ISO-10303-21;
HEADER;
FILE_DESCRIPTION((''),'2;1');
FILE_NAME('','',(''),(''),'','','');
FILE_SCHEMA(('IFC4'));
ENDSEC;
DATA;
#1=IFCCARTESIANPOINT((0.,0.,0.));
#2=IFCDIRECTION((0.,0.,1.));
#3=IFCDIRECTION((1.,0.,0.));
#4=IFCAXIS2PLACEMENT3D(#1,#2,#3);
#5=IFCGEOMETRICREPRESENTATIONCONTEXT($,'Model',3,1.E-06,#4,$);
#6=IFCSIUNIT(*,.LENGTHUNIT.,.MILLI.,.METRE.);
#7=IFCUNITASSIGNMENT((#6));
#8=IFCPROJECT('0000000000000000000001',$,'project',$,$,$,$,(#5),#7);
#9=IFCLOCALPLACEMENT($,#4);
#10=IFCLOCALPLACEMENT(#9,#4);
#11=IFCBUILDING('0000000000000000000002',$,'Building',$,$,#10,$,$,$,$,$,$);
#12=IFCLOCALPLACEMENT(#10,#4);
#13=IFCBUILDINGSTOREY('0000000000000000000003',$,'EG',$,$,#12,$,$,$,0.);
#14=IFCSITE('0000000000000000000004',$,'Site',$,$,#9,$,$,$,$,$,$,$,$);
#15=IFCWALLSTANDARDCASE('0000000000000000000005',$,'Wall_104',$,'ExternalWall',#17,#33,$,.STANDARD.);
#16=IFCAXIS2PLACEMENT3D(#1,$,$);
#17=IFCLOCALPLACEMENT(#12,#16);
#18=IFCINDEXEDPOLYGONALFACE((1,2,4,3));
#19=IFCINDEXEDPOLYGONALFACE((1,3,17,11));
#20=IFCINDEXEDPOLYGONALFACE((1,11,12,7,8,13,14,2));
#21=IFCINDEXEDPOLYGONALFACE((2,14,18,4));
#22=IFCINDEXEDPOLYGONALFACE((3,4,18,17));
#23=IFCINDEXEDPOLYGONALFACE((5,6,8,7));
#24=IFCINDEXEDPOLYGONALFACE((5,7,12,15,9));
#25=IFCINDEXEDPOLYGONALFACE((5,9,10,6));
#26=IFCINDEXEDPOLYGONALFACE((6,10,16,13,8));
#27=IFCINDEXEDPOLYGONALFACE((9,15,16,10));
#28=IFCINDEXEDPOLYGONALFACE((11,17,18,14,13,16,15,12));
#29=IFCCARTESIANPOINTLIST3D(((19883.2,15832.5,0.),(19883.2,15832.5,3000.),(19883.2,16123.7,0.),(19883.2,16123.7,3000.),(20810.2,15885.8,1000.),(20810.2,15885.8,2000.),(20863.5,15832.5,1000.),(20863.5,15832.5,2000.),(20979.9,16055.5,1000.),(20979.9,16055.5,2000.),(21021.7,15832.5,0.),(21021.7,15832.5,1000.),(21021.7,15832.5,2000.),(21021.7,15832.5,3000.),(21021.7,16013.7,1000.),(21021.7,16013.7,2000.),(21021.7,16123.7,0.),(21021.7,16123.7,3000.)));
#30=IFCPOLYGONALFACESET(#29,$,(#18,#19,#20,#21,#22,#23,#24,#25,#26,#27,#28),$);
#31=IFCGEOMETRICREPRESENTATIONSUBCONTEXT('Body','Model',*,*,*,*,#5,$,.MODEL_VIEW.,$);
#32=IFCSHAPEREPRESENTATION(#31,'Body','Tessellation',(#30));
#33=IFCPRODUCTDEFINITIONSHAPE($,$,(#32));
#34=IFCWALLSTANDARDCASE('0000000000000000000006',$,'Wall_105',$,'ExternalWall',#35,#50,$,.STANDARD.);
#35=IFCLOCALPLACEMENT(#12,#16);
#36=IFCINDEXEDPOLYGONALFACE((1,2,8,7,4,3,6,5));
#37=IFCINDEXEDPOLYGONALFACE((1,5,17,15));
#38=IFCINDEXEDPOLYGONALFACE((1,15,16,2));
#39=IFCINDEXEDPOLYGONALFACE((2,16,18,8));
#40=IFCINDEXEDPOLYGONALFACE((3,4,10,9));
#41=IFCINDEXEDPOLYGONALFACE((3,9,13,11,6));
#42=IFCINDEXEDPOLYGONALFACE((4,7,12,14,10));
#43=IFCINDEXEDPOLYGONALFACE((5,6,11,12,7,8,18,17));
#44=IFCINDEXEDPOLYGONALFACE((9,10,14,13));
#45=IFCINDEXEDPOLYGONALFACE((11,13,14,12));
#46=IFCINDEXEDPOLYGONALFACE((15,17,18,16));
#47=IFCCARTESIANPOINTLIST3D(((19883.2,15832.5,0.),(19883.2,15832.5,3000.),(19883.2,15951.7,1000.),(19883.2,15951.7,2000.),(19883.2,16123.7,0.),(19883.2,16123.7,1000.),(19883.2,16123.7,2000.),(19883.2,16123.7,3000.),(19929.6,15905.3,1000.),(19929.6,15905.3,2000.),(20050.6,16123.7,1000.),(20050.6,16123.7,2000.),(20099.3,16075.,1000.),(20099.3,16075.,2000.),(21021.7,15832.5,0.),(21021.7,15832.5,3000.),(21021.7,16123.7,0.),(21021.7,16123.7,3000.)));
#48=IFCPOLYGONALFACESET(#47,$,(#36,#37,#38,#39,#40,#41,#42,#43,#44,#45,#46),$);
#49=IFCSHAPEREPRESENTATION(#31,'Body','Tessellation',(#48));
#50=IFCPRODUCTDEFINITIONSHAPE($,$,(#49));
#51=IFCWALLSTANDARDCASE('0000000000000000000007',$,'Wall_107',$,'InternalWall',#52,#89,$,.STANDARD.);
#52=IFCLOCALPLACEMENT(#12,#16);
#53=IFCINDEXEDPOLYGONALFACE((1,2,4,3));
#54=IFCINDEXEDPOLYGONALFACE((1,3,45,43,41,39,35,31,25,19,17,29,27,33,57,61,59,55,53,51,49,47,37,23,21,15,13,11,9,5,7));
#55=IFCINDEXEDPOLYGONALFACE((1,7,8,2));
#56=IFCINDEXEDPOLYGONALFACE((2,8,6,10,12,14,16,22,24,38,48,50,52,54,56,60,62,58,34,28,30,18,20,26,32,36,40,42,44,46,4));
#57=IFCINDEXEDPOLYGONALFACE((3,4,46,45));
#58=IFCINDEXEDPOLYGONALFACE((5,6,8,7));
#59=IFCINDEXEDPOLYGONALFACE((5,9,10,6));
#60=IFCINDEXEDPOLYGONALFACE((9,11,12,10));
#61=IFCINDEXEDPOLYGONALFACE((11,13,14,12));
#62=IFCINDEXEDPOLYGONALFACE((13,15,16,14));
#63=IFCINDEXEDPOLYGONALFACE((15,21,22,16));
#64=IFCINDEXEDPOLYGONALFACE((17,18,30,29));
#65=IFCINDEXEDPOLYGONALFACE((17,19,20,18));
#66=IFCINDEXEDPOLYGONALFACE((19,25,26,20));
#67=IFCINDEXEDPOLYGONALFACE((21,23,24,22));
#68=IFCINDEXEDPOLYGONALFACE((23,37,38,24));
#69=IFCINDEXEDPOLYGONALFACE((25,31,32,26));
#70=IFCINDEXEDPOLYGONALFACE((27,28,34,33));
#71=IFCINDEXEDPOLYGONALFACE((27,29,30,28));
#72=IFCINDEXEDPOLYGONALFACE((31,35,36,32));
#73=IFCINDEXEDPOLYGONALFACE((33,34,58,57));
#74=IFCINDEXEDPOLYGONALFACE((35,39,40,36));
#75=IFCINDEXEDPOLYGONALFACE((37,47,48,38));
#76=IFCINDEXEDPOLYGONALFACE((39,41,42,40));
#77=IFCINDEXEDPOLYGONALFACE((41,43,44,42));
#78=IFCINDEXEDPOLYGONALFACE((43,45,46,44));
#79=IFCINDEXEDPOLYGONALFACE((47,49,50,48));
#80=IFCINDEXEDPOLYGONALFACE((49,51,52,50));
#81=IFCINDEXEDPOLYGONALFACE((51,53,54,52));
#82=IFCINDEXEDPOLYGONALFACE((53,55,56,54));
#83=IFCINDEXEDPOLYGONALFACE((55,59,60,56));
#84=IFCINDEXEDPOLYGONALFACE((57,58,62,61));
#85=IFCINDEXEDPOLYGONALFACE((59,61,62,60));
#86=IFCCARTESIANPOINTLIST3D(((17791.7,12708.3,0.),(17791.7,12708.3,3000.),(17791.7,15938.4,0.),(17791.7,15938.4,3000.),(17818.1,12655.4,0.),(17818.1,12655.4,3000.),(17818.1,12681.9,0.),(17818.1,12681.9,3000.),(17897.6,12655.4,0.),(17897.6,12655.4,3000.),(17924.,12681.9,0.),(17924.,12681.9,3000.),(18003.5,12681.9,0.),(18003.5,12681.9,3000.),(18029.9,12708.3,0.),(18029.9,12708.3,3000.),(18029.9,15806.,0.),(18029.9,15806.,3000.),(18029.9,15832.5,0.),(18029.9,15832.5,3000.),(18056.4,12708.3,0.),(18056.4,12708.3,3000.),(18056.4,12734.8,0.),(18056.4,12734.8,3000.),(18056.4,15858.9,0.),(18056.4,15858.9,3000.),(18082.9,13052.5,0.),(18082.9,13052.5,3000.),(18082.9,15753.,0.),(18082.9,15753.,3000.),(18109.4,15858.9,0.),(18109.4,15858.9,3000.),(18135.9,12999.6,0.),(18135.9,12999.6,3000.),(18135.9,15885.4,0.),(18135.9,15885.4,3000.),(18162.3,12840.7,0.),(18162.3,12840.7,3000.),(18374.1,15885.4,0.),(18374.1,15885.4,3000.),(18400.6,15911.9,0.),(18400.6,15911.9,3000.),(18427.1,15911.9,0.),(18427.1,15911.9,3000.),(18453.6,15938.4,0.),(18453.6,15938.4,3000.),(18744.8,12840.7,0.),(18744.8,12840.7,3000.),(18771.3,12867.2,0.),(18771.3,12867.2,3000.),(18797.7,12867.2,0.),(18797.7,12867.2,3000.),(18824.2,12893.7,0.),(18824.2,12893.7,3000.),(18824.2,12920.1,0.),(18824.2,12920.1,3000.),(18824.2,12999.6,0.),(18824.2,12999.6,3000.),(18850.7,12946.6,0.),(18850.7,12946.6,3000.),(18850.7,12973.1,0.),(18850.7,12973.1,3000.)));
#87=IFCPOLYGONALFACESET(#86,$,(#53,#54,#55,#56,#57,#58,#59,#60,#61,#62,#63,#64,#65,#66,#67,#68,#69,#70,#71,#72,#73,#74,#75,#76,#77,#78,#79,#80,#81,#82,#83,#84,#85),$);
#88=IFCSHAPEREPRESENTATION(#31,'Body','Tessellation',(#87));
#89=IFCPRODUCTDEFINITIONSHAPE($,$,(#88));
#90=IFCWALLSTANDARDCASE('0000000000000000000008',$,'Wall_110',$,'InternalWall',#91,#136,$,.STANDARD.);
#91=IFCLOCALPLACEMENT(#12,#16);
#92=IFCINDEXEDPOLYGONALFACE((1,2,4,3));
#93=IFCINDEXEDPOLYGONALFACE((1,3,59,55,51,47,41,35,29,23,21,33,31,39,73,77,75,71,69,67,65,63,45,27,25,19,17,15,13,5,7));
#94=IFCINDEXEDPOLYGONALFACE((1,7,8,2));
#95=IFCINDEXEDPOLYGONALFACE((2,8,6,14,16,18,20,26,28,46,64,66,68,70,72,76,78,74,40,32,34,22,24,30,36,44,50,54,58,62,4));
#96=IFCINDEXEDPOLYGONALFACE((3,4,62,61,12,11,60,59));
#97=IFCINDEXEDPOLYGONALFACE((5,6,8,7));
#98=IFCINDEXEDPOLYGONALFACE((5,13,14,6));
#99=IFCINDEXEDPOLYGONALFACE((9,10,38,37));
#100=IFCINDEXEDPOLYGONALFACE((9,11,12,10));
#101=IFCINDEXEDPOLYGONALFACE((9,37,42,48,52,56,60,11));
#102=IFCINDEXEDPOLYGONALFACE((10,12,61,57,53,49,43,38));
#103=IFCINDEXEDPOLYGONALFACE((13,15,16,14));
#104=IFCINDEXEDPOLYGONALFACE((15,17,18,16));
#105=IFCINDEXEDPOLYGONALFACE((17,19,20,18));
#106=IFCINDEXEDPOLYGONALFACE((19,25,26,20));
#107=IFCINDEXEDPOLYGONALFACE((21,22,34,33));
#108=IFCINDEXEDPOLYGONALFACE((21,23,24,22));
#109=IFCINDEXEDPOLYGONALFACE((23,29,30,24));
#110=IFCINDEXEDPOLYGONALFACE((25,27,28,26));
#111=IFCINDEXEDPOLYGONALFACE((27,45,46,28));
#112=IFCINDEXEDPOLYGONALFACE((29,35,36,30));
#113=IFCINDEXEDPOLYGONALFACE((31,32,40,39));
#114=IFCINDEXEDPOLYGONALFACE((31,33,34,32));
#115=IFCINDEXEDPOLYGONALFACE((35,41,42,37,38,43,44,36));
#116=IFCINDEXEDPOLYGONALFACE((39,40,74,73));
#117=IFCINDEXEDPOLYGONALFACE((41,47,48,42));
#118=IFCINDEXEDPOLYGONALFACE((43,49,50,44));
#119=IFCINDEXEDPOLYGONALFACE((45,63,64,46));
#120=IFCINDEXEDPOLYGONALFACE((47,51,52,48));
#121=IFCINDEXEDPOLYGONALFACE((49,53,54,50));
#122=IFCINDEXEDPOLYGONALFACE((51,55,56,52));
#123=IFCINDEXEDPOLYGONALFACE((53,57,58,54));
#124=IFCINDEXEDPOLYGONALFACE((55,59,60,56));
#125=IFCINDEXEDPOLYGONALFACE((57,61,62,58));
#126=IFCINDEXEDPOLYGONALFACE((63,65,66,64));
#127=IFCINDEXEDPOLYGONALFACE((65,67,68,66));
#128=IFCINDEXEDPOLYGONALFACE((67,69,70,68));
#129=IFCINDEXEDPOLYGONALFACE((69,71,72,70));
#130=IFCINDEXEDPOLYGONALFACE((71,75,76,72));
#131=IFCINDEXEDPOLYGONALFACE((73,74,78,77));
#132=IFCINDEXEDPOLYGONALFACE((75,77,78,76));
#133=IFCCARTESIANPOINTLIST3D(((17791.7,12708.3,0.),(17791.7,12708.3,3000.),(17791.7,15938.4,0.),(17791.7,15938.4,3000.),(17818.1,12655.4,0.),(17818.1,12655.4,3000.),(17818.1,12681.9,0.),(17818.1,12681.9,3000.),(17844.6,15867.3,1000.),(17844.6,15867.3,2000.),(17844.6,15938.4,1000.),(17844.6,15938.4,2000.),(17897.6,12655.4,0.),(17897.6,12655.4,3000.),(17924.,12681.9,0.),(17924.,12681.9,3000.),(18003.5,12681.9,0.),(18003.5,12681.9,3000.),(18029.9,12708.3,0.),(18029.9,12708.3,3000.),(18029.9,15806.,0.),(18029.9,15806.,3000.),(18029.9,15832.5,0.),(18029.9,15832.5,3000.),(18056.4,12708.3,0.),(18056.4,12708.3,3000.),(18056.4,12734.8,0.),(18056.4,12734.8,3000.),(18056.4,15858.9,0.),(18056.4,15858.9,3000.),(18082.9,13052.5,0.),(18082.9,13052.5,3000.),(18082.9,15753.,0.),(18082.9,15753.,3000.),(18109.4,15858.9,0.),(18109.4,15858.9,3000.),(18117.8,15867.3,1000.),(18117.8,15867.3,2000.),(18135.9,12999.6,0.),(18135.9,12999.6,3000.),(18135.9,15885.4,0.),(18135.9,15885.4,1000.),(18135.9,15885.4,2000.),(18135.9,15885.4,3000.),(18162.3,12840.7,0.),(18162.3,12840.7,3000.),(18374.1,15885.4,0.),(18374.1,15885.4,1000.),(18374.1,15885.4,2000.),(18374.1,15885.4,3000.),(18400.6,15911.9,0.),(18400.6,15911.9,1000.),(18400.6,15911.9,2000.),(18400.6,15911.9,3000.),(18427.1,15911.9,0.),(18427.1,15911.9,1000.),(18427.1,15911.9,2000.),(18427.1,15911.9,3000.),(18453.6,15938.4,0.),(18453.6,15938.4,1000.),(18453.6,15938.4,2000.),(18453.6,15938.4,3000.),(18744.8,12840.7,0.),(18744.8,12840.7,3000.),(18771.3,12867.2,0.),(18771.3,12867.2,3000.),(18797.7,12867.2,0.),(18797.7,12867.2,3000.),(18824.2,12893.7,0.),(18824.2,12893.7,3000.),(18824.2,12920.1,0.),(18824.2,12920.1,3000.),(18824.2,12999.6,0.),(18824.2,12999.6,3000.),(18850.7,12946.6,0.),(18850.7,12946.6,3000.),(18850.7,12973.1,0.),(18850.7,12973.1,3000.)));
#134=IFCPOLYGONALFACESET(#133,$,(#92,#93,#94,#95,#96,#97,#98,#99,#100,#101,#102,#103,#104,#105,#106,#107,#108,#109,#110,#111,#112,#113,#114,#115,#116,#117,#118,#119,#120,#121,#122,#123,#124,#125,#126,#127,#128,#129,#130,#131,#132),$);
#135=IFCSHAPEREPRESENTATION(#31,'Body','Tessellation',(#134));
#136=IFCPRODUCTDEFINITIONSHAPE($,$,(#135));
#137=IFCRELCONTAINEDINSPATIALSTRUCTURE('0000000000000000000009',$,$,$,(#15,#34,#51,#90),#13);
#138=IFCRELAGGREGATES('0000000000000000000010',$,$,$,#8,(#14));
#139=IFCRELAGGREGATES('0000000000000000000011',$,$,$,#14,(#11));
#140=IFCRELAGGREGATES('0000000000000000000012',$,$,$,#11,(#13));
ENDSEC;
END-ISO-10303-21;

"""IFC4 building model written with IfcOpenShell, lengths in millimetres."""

from ifc_helpers import new_model, si_unit, frame, origin_with_axes, place, context, subcontext, project, spatial, polyline, rectangle, outline, extrude, element, save


model = new_model("IFC4")

# Units and contexts
model_context = context("Model", 3, precision=1e-06, world=origin_with_axes())
body_context = subcontext(model_context, "Body", "Model", "MODEL_VIEW")
ifc_project = project(units=[si_unit("LENGTHUNIT", "METRE", prefix="MILLI")], contexts=[model_context])

# Site, building, storey
site_placement = place(None, origin_with_axes())
site = spatial("IfcSite", under=ifc_project, at=site_placement, Name="Site")
building_placement = place(site_placement, origin_with_axes())
building = spatial("IfcBuilding", under=site, at=building_placement, Name="Building")
storey_placement = place(building_placement, origin_with_axes())
storey = spatial("IfcBuildingStorey", under=building, at=storey_placement, Name="EG", Elevation=0.0)

# Walls, openings
wall_1_placement = place(storey_placement, origin_with_axes())
wall_1 = element("IfcWallStandardCase", 1, at=wall_1_placement, inside=storey, Name="Wall_104", ObjectType="ExternalWall", PredefinedType="STANDARD", context=body_context, shape_type="SweptSolid", body=[
    extrude(outline(polyline([(19883.2, 15832.5, 0.0), (19883.2, 16123.7, 0.0), (21021.7, 16123.7, 0.0), (21021.7, 15832.5, 0.0), (19883.2, 15832.5, 0.0)])), origin_with_axes(), (0.0, 0.0, 1.0), 3000.0),
])
opening_1_placement = place(wall_1_placement, origin_with_axes())
element("IfcOpeningElement", 2, at=opening_1_placement, inside=storey, cuts=wall_1, context=body_context, shape_type="SweptSolid", body=[
    extrude(rectangle(XDim=2096.8, YDim=240.0), frame((21636.4, 15229.3, 1000.0), z_axis=(0.0, 0.0, 1.0), x_axis=(0.707107, -0.707107, 0.0)), (0.0, 0.0, 1.0), 1000.0),
])
wall_2_placement = place(storey_placement, origin_with_axes())
wall_2 = element("IfcWallStandardCase", 3, at=wall_2_placement, inside=storey, Name="Wall_105", ObjectType="ExternalWall", PredefinedType="STANDARD", context=body_context, shape_type="SweptSolid", body=[
    extrude(outline(polyline([(19883.2, 15832.5, 0.0), (19883.2, 16123.7, 0.0), (21021.7, 16123.7, 0.0), (21021.7, 15832.5, 0.0), (19883.2, 15832.5, 0.0)])), origin_with_axes(), (0.0, 0.0, 1.0), 3000.0),
])
opening_2_placement = place(wall_2_placement, origin_with_axes())
element("IfcOpeningElement", 4, at=opening_2_placement, inside=storey, cuts=wall_2, context=body_context, shape_type="SweptSolid", body=[
    extrude(rectangle(XDim=1123.3, YDim=240.0), frame((19617.3, 16387.3, 1000.0), z_axis=(0.0, 0.0, 1.0), x_axis=(-0.707107, 0.707107, 0.0)), (0.0, 0.0, 1.0), 1000.0),
])

# Wall
for number, where, z_axis, x_axis, name in (
    (5, (0.0, 0.0, 0.0), (0.0, 0.0, 1.0), (1.0, 0.0, 0.0), "Wall_107"),
):
    element("IfcWallStandardCase", number, at=place(storey_placement, frame(where, z_axis=z_axis, x_axis=x_axis)), inside=storey, Name=name, ObjectType="InternalWall", PredefinedType="STANDARD", context=body_context, shape_type="SweptSolid", body=[
        extrude(outline(polyline([(17818.1, 12655.4, 0.0), (17818.1, 12681.9, 0.0), (17791.7, 12708.3, 0.0), (17791.7, 15938.4, 0.0), (18453.6, 15938.4, 0.0), (18427.1, 15911.9, 0.0), (18400.6, 15911.9, 0.0), (18374.1, 15885.4, 0.0), (18135.9, 15885.4, 0.0), (18109.4, 15858.9, 0.0), (18056.4, 15858.9, 0.0), (18029.9, 15832.5, 0.0), (18029.9, 15806.0, 0.0), (18082.9, 15753.0, 0.0), (18082.9, 13052.5, 0.0), (18135.9, 12999.6, 0.0), (18824.2, 12999.6, 0.0), (18850.7, 12973.1, 0.0), (18850.7, 12946.6, 0.0), (18824.2, 12920.1, 0.0), (18824.2, 12893.7, 0.0), (18797.7, 12867.2, 0.0), (18771.3, 12867.2, 0.0), (18744.8, 12840.7, 0.0), (18162.3, 12840.7, 0.0), (18056.4, 12734.8, 0.0), (18056.4, 12708.3, 0.0), (18029.9, 12708.3, 0.0), (18003.5, 12681.9, 0.0), (17924.0, 12681.9, 0.0), (17897.6, 12655.4, 0.0), (17818.1, 12655.4, 0.0)])), origin_with_axes(), (0.0, 0.0, 1.0), 3000.0),
    ])

# Wall, opening
wall_3_placement = place(storey_placement, origin_with_axes())
wall_3 = element("IfcWallStandardCase", 6, at=wall_3_placement, inside=storey, Name="Wall_110", ObjectType="InternalWall", PredefinedType="STANDARD", context=body_context, shape_type="SweptSolid", body=[
    extrude(outline(polyline([(17818.1, 12655.4, 0.0), (17818.1, 12681.9, 0.0), (17791.7, 12708.3, 0.0), (17791.7, 15938.4, 0.0), (18453.6, 15938.4, 0.0), (18427.1, 15911.9, 0.0), (18400.6, 15911.9, 0.0), (18374.1, 15885.4, 0.0), (18135.9, 15885.4, 0.0), (18109.4, 15858.9, 0.0), (18056.4, 15858.9, 0.0), (18029.9, 15832.5, 0.0), (18029.9, 15806.0, 0.0), (18082.9, 15753.0, 0.0), (18082.9, 13052.5, 0.0), (18135.9, 12999.6, 0.0), (18824.2, 12999.6, 0.0), (18850.7, 12973.1, 0.0), (18850.7, 12946.6, 0.0), (18824.2, 12920.1, 0.0), (18824.2, 12893.7, 0.0), (18797.7, 12867.2, 0.0), (18771.3, 12867.2, 0.0), (18744.8, 12840.7, 0.0), (18162.3, 12840.7, 0.0), (18056.4, 12734.8, 0.0), (18056.4, 12708.3, 0.0), (18029.9, 12708.3, 0.0), (18003.5, 12681.9, 0.0), (17924.0, 12681.9, 0.0), (17897.6, 12655.4, 0.0), (17818.1, 12655.4, 0.0)])), origin_with_axes(), (0.0, 0.0, 1.0), 3000.0),
])
opening_3_placement = place(wall_3_placement, origin_with_axes())
element("IfcOpeningElement", 7, at=opening_3_placement, inside=storey, cuts=wall_3, context=body_context, shape_type="SweptSolid", body=[
    extrude(rectangle(XDim=1985.7, YDim=115.0), frame((18837.5, 15924.8, 1000.0), z_axis=(0.0, 0.0, 1.0), x_axis=(1.0, 0.0, 0.0)), (0.0, 0.0, 1.0), 1000.0),
])

save(model, "model.ifc")
